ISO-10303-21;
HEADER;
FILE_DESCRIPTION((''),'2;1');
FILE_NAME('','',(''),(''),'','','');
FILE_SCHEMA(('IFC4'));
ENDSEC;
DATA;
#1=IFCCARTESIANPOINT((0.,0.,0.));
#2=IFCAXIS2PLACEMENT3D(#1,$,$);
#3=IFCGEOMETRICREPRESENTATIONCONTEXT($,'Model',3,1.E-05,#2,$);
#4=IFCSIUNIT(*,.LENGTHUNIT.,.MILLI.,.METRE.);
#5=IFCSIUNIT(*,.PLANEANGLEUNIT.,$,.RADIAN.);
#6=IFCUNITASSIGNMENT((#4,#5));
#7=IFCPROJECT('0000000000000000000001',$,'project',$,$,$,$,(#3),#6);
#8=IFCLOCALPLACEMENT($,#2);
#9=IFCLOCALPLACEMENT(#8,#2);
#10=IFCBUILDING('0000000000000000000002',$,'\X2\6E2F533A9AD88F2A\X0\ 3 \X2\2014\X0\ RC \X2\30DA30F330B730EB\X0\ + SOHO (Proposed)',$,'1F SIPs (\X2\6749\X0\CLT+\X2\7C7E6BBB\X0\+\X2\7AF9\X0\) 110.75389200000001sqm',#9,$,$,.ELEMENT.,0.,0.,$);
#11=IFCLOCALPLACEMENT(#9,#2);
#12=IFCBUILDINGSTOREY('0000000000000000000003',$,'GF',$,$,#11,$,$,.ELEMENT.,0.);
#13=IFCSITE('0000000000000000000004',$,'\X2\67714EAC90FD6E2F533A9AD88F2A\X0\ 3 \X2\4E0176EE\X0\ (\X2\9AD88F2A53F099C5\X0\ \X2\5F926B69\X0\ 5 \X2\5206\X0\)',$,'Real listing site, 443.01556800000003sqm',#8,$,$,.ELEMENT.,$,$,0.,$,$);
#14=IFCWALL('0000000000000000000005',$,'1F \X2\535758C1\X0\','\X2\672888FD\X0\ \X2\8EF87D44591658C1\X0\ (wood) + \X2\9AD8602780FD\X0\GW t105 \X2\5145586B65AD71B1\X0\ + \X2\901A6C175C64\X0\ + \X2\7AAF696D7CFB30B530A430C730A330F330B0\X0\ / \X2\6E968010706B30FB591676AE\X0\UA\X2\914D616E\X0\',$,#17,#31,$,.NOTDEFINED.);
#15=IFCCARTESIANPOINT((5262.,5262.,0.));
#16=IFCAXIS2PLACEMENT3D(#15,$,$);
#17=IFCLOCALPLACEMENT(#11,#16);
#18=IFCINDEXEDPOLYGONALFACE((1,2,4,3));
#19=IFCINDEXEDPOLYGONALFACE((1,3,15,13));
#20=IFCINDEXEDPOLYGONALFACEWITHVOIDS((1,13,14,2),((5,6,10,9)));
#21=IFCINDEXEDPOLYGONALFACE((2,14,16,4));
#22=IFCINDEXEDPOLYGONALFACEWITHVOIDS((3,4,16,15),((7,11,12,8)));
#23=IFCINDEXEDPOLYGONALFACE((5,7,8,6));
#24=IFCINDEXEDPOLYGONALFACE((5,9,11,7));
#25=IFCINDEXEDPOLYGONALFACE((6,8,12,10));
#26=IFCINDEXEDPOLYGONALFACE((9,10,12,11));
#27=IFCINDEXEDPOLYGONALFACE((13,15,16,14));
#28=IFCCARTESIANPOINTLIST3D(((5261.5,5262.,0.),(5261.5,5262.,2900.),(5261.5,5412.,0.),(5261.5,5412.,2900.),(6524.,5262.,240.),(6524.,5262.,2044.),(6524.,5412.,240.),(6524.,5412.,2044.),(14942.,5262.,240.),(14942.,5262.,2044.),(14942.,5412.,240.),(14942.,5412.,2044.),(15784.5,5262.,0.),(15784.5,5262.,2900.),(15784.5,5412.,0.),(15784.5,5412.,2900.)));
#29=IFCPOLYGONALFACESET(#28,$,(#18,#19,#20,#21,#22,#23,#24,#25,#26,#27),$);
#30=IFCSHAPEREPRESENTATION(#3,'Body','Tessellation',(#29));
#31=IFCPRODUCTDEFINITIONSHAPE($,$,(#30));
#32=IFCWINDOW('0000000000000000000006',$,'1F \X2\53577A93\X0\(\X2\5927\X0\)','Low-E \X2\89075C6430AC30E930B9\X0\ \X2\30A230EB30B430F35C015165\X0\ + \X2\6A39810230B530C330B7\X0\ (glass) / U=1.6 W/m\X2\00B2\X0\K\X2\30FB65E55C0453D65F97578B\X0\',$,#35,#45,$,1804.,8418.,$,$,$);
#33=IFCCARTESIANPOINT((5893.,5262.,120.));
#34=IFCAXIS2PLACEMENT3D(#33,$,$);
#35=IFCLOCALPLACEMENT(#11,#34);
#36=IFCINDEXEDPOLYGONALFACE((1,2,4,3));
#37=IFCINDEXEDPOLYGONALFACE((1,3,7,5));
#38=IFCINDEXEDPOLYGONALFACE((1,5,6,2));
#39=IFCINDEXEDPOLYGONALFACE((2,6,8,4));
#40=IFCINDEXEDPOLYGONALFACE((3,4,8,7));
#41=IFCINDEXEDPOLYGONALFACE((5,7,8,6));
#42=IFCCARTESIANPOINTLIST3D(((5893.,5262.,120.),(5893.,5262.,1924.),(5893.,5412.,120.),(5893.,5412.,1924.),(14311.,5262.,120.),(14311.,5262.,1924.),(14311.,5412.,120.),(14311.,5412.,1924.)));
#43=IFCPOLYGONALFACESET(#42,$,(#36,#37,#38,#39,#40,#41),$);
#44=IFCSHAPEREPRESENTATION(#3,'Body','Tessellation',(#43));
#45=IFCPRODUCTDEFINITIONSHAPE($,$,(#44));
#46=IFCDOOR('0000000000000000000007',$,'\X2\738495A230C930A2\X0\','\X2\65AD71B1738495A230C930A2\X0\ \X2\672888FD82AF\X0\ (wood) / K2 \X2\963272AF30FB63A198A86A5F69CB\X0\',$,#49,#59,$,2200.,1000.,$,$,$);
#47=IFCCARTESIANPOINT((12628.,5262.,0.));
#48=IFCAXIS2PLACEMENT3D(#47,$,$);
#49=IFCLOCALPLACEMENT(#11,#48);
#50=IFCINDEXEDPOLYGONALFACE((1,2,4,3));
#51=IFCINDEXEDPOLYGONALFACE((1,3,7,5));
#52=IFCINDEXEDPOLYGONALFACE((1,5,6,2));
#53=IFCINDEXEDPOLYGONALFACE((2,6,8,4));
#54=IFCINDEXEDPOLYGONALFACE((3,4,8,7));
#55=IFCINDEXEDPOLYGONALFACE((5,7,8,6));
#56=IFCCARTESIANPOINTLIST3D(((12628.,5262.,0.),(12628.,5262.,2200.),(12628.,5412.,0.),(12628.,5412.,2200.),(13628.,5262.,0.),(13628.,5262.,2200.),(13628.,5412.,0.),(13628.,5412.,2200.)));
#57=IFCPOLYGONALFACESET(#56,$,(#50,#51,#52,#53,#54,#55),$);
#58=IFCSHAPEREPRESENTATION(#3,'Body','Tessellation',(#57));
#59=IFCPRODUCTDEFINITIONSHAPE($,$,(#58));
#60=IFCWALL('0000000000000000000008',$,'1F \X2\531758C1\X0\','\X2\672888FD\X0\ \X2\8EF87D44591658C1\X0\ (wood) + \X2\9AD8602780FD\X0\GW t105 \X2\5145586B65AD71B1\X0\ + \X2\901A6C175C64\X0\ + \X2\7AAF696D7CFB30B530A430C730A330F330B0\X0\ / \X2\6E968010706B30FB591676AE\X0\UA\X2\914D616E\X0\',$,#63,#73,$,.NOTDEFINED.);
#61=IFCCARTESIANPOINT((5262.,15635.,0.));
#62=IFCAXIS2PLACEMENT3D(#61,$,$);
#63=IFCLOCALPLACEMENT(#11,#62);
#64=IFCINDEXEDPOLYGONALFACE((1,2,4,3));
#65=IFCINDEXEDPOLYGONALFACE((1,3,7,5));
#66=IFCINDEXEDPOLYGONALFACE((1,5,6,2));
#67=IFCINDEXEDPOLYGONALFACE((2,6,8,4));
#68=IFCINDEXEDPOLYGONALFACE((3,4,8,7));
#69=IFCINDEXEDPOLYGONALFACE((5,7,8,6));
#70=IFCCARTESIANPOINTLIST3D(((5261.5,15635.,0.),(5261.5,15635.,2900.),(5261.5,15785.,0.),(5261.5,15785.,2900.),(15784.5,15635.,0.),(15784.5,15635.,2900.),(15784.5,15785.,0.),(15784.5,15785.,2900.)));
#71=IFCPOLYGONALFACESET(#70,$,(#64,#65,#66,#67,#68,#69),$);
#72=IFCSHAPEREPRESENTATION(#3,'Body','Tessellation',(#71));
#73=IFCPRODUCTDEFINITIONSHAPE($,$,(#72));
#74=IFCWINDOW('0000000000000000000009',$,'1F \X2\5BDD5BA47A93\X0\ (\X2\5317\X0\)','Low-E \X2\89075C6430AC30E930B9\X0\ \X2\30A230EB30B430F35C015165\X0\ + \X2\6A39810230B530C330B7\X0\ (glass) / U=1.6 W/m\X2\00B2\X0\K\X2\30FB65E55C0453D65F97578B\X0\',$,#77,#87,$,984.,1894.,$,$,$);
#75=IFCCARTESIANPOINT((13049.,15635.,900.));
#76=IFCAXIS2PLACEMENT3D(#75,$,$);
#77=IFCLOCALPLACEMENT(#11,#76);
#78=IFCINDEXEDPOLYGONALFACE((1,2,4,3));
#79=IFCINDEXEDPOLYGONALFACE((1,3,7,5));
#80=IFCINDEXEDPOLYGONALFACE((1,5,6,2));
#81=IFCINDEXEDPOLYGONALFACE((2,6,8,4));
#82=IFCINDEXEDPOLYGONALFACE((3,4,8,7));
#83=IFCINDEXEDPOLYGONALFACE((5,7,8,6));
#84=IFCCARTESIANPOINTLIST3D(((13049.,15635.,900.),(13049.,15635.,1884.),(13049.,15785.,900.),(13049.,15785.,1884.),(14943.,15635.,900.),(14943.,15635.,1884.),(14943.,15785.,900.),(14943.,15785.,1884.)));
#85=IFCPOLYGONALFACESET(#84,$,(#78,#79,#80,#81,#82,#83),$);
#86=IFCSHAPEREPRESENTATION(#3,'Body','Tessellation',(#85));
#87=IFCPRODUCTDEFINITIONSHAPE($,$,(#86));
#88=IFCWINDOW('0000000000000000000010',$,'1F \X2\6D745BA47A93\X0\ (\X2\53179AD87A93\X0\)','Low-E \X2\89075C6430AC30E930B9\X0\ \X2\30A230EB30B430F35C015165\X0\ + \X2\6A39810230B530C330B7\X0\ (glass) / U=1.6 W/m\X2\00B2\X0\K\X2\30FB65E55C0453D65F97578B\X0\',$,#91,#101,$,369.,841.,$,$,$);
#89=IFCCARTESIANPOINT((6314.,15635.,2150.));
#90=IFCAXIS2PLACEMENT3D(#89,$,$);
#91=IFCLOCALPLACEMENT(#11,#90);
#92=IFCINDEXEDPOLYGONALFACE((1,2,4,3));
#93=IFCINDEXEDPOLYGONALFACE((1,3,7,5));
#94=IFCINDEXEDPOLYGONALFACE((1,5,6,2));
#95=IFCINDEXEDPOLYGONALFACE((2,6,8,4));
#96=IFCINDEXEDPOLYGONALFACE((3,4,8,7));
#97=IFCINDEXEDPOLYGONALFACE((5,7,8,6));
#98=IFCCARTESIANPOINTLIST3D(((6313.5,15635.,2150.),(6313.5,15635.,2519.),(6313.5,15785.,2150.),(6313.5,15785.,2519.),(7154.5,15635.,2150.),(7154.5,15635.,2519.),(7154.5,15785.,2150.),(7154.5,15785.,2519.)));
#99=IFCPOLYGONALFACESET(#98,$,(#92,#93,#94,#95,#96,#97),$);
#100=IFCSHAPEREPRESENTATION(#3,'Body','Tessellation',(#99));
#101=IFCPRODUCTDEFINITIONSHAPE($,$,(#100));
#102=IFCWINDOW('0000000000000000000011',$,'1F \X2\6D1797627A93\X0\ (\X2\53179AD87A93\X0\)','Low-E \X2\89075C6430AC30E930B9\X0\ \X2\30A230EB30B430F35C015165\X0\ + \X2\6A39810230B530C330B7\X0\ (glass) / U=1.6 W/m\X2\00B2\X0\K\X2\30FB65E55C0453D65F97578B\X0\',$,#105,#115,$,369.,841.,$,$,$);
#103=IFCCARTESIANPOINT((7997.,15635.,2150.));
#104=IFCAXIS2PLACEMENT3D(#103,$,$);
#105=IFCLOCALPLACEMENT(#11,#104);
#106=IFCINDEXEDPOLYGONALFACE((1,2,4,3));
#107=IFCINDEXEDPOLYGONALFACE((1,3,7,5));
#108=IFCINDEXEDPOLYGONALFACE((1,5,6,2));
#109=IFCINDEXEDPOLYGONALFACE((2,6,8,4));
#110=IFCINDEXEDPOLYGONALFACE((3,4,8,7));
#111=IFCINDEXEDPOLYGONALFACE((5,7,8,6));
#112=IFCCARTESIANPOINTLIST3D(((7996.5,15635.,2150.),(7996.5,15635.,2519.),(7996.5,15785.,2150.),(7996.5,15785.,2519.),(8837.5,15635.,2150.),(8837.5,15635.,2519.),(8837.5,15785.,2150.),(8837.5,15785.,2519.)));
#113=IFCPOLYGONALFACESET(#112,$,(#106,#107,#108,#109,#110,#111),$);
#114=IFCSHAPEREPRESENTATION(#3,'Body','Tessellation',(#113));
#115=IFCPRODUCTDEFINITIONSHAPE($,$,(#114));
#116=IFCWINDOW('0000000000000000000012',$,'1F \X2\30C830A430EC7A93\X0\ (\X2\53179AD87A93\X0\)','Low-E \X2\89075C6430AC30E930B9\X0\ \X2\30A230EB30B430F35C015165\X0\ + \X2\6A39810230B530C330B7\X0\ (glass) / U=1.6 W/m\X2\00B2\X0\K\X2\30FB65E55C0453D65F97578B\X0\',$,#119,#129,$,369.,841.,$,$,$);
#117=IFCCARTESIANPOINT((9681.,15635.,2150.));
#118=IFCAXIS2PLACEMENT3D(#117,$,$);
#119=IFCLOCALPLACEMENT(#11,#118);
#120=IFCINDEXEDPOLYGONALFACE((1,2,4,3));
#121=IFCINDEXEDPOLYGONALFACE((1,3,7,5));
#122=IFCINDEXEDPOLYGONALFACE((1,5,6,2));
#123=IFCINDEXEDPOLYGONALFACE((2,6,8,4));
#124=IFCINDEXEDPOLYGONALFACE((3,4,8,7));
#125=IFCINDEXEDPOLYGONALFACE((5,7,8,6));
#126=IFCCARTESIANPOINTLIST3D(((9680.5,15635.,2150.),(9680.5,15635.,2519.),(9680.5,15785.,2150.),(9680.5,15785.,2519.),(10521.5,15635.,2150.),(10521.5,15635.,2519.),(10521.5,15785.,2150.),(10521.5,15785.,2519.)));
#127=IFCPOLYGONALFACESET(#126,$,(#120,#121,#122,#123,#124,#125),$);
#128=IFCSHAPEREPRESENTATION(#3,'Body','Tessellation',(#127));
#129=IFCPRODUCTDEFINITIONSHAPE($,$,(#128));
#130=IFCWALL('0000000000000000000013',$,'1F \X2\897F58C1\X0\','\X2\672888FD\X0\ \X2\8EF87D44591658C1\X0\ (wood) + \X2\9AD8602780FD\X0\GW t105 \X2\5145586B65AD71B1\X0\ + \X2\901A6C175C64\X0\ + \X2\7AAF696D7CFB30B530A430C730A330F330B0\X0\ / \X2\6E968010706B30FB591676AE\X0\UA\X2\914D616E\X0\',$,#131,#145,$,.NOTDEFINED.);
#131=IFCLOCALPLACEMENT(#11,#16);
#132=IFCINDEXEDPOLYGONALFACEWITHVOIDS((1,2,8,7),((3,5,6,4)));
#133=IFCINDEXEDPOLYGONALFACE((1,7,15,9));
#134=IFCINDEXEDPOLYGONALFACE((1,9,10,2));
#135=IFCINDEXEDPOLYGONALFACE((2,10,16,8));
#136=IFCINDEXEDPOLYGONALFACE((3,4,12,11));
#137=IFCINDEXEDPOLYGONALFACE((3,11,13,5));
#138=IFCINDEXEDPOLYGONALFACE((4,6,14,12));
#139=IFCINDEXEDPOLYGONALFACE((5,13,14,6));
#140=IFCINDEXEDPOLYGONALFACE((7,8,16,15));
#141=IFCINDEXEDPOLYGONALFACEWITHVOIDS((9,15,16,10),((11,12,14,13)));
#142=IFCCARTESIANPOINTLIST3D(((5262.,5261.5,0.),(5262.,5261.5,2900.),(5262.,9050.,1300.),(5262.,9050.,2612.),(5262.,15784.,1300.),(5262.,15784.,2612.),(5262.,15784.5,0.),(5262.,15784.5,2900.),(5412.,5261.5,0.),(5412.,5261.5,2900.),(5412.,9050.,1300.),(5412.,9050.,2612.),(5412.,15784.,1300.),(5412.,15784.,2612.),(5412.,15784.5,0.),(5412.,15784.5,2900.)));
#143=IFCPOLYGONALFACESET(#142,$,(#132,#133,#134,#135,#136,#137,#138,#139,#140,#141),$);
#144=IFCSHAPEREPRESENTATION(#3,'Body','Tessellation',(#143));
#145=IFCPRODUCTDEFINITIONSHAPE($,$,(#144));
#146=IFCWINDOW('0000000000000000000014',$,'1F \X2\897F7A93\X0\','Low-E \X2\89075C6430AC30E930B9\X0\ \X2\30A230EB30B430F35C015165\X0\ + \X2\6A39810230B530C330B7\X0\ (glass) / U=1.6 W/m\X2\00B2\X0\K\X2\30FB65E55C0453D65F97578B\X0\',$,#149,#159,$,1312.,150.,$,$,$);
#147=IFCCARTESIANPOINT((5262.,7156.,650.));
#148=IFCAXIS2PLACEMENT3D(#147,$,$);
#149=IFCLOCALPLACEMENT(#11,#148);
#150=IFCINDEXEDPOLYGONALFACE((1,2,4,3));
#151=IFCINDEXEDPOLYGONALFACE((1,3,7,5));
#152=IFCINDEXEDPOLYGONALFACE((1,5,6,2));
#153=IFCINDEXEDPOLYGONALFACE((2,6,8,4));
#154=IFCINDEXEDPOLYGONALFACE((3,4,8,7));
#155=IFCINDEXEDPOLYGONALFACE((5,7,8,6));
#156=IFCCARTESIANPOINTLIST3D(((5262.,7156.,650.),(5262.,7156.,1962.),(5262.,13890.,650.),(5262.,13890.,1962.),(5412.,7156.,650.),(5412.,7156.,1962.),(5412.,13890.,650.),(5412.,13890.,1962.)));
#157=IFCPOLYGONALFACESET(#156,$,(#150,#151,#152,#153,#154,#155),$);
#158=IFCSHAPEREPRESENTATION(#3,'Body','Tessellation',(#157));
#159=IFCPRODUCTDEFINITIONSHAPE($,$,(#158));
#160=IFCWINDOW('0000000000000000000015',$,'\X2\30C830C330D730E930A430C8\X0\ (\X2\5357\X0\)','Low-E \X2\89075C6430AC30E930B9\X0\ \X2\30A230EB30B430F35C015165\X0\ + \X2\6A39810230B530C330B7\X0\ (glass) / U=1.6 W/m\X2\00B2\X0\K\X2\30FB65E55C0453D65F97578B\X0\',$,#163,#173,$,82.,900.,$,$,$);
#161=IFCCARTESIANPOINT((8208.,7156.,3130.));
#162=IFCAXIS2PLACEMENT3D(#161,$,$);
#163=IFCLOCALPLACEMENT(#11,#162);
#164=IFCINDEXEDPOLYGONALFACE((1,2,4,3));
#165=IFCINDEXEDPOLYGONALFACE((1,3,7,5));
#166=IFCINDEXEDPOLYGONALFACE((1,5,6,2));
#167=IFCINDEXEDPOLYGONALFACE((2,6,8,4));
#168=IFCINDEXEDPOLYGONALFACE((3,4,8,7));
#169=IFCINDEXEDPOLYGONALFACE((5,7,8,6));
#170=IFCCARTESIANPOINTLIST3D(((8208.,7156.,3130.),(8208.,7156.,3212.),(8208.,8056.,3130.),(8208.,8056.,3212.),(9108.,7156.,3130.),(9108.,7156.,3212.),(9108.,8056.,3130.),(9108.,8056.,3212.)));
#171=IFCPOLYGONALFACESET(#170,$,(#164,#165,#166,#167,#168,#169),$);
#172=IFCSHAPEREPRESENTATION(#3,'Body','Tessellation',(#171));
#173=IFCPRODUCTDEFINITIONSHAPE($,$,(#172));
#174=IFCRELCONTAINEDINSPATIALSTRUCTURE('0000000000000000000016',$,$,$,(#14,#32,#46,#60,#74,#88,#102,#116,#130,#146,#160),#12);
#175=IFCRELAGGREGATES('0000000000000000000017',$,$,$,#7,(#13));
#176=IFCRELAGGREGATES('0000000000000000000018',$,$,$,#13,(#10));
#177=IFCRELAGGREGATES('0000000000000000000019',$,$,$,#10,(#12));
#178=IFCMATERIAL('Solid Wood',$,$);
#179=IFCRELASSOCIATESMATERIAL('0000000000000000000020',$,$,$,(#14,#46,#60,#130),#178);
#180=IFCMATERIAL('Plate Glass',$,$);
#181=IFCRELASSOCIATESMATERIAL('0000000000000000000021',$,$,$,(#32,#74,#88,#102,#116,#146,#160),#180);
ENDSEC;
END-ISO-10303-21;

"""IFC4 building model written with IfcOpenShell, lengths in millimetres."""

from ifc_helpers import new_model, si_unit, frame, frame_2d, origin, place, context, project, spatial, rectangle, extrude, material, element, fill, save


model = new_model("IFC4")

# Units and contexts
model_context = context("Model", 3, precision=1e-05, world=origin())
ifc_project = project(units=[si_unit("LENGTHUNIT", "METRE", prefix="MILLI"), si_unit("PLANEANGLEUNIT", "RADIAN")], contexts=[model_context])

# Site, building, storey
site_placement = place(None, origin())
site = spatial("IfcSite", under=ifc_project, at=site_placement, Name="東京都港区高輪 3 丁目 (高輪台駅 徒歩 5 分)", ObjectType="Real listing site, 443.01556800000003sqm", CompositionType="ELEMENT", RefElevation=0.0)
building_placement = place(site_placement, origin())
building = spatial("IfcBuilding", under=site, at=building_placement, Name="港区高輪 3 — RC ペンシル + SOHO (Proposed)", ObjectType="1F SIPs (杉CLT+籾殻+竹) 110.75389200000001sqm", CompositionType="ELEMENT", ElevationOfRefHeight=0.0, ElevationOfTerrain=0.0)
storey_placement = place(building_placement, origin())
storey = spatial("IfcBuildingStorey", under=building, at=storey_placement, Name="GF", CompositionType="ELEMENT", Elevation=0.0)

# Shared definitions
ifc_material_1 = material(Name="Solid Wood")

# Wall, openings, window, door
wall_1_placement = place(storey_placement, frame((5262.0, 5262.0, 0.0)))
wall_1 = element("IfcWall", 1, at=wall_1_placement, inside=storey, material=ifc_material_1, Name="1F 南壁", Description="木製 軸組外壁 (wood) + 高性能GW t105 充填断熱 + 通気層 + 窯業系サイディング / 準耐火・外皮UA配慮", PredefinedType="NOTDEFINED", context=model_context, shape_type="SweptSolid", body=[
    extrude(rectangle(XDim=10523.0, YDim=150.0, at=frame_2d((5261.0, 75.0))), frame((5262.0, 5262.0, 0.0)), (0.0, 0.0, 1.0), 2900.0),
])
opening_1_placement = place(storey_placement, frame((5893.0, 5262.0, 120.0)))
opening_1 = element("IfcOpeningElement", 2, at=opening_1_placement, cuts=wall_1, PredefinedType="NOTDEFINED", context=model_context, shape_type="SweptSolid", body=[
    extrude(rectangle(XDim=8418.0, YDim=150.0, at=frame_2d((4209.0, 75.0))), frame((5893.0, 5262.0, 120.0)), (0.0, 0.0, 1.0), 1804.0),
])
opening_2_placement = place(storey_placement, frame((12628.0, 5262.0, 0.0)))
opening_2 = element("IfcOpeningElement", 3, at=opening_2_placement, cuts=wall_1, PredefinedType="NOTDEFINED", context=model_context, shape_type="SweptSolid", body=[
    extrude(rectangle(XDim=1000.0, YDim=150.0, at=frame_2d((500.0, 75.0))), frame((12628.0, 5262.0, 0.0)), (0.0, 0.0, 1.0), 2200.0),
])
ifc_material_2 = material(Name="Plate Glass")
window_1_placement = place(storey_placement, frame((5893.0, 5262.0, 120.0)))
window_1 = element("IfcWindow", 4, at=window_1_placement, inside=storey, material=ifc_material_2, Name="1F 南窓(大)", Description="Low-E 複層ガラス アルゴン封入 + 樹脂サッシ (glass) / U=1.6 W/m²K・日射取得型", OverallHeight=1804.0, OverallWidth=8418.0, context=model_context, shape_type="SweptSolid", body=[
    extrude(rectangle(XDim=8418.0, YDim=150.0, at=frame_2d((4209.0, 75.0))), frame((5893.0, 5262.0, 120.0)), (0.0, 0.0, 1.0), 1804.0),
])
fill(opening_1, window_1)
door_1_placement = place(storey_placement, frame((12628.0, 5262.0, 0.0)))
door_1 = element("IfcDoor", 5, at=door_1_placement, inside=storey, material=ifc_material_1, Name="玄関ドア", Description="断熱玄関ドア 木製芯 (wood) / K2 防犯・採風機構", OverallHeight=2200.0, OverallWidth=1000.0, context=model_context, shape_type="SweptSolid", body=[
    extrude(rectangle(XDim=1000.0, YDim=150.0, at=frame_2d((500.0, 75.0))), frame((12628.0, 5262.0, 0.0)), (0.0, 0.0, 1.0), 2200.0),
])
fill(opening_2, door_1)

# Wall, openings, windows
wall_2_placement = place(storey_placement, frame((5262.0, 15635.0, 0.0)))
wall_2 = element("IfcWall", 6, at=wall_2_placement, inside=storey, material=ifc_material_1, Name="1F 北壁", Description="木製 軸組外壁 (wood) + 高性能GW t105 充填断熱 + 通気層 + 窯業系サイディング / 準耐火・外皮UA配慮", PredefinedType="NOTDEFINED", context=model_context, shape_type="SweptSolid", body=[
    extrude(rectangle(XDim=10523.0, YDim=150.0, at=frame_2d((5261.0, 75.0))), frame((5262.0, 15635.0, 0.0)), (0.0, 0.0, 1.0), 2900.0),
])
opening_3_placement = place(storey_placement, frame((13049.0, 15635.0, 900.0)))
opening_3 = element("IfcOpeningElement", 7, at=opening_3_placement, cuts=wall_2, PredefinedType="NOTDEFINED", context=model_context, shape_type="SweptSolid", body=[
    extrude(rectangle(XDim=1894.0, YDim=150.0, at=frame_2d((947.0, 75.0))), frame((13049.0, 15635.0, 900.0)), (0.0, 0.0, 1.0), 984.0),
])
opening_4_placement = place(storey_placement, frame((6314.0, 15635.0, 2150.0)))
opening_4 = element("IfcOpeningElement", 8, at=opening_4_placement, cuts=wall_2, PredefinedType="NOTDEFINED", context=model_context, shape_type="SweptSolid", body=[
    extrude(rectangle(XDim=841.0, YDim=150.0, at=frame_2d((420.0, 75.0))), frame((6314.0, 15635.0, 2150.0)), (0.0, 0.0, 1.0), 369.0),
])
opening_5_placement = place(storey_placement, frame((7997.0, 15635.0, 2150.0)))
opening_5 = element("IfcOpeningElement", 9, at=opening_5_placement, cuts=wall_2, PredefinedType="NOTDEFINED", context=model_context, shape_type="SweptSolid", body=[
    extrude(rectangle(XDim=841.0, YDim=150.0, at=frame_2d((420.0, 75.0))), frame((7997.0, 15635.0, 2150.0)), (0.0, 0.0, 1.0), 369.0),
])
opening_6_placement = place(storey_placement, frame((9681.0, 15635.0, 2150.0)))
opening_6 = element("IfcOpeningElement", 10, at=opening_6_placement, cuts=wall_2, PredefinedType="NOTDEFINED", context=model_context, shape_type="SweptSolid", body=[
    extrude(rectangle(XDim=841.0, YDim=150.0, at=frame_2d((420.0, 75.0))), frame((9681.0, 15635.0, 2150.0)), (0.0, 0.0, 1.0), 369.0),
])
window_2_placement = place(storey_placement, frame((13049.0, 15635.0, 900.0)))
window_2 = element("IfcWindow", 11, at=window_2_placement, inside=storey, material=ifc_material_2, Name="1F 寝室窓 (北)", Description="Low-E 複層ガラス アルゴン封入 + 樹脂サッシ (glass) / U=1.6 W/m²K・日射取得型", OverallHeight=984.0, OverallWidth=1894.0, context=model_context, shape_type="SweptSolid", body=[
    extrude(rectangle(XDim=1894.0, YDim=150.0, at=frame_2d((947.0, 75.0))), frame((13049.0, 15635.0, 900.0)), (0.0, 0.0, 1.0), 984.0),
])
fill(opening_3, window_2)
window_3_placement = place(storey_placement, frame((6314.0, 15635.0, 2150.0)))
window_3 = element("IfcWindow", 12, at=window_3_placement, inside=storey, material=ifc_material_2, Name="1F 浴室窓 (北高窓)", Description="Low-E 複層ガラス アルゴン封入 + 樹脂サッシ (glass) / U=1.6 W/m²K・日射取得型", OverallHeight=369.0, OverallWidth=841.0, context=model_context, shape_type="SweptSolid", body=[
    extrude(rectangle(XDim=841.0, YDim=150.0, at=frame_2d((420.0, 75.0))), frame((6314.0, 15635.0, 2150.0)), (0.0, 0.0, 1.0), 369.0),
])
fill(opening_4, window_3)
window_4_placement = place(storey_placement, frame((7997.0, 15635.0, 2150.0)))
window_4 = element("IfcWindow", 13, at=window_4_placement, inside=storey, material=ifc_material_2, Name="1F 洗面窓 (北高窓)", Description="Low-E 複層ガラス アルゴン封入 + 樹脂サッシ (glass) / U=1.6 W/m²K・日射取得型", OverallHeight=369.0, OverallWidth=841.0, context=model_context, shape_type="SweptSolid", body=[
    extrude(rectangle(XDim=841.0, YDim=150.0, at=frame_2d((420.0, 75.0))), frame((7997.0, 15635.0, 2150.0)), (0.0, 0.0, 1.0), 369.0),
])
fill(opening_5, window_4)
window_5_placement = place(storey_placement, frame((9681.0, 15635.0, 2150.0)))
window_5 = element("IfcWindow", 14, at=window_5_placement, inside=storey, material=ifc_material_2, Name="1F トイレ窓 (北高窓)", Description="Low-E 複層ガラス アルゴン封入 + 樹脂サッシ (glass) / U=1.6 W/m²K・日射取得型", OverallHeight=369.0, OverallWidth=841.0, context=model_context, shape_type="SweptSolid", body=[
    extrude(rectangle(XDim=841.0, YDim=150.0, at=frame_2d((420.0, 75.0))), frame((9681.0, 15635.0, 2150.0)), (0.0, 0.0, 1.0), 369.0),
])
fill(opening_6, window_5)

# Wall, opening, window
wall_3_placement = place(storey_placement, frame((5262.0, 5262.0, 0.0)))
wall_3 = element("IfcWall", 15, at=wall_3_placement, inside=storey, material=ifc_material_1, Name="1F 西壁", Description="木製 軸組外壁 (wood) + 高性能GW t105 充填断熱 + 通気層 + 窯業系サイディング / 準耐火・外皮UA配慮", PredefinedType="NOTDEFINED", context=model_context, shape_type="SweptSolid", body=[
    extrude(rectangle(XDim=150.0, YDim=10523.0, at=frame_2d((75.0, 5261.0))), frame((5262.0, 5262.0, 0.0)), (0.0, 0.0, 1.0), 2900.0),
])
opening_7_placement = place(storey_placement, frame((5262.0, 7156.0, 650.0)))
opening_7 = element("IfcOpeningElement", 16, at=opening_7_placement, cuts=wall_3, PredefinedType="NOTDEFINED", context=model_context, shape_type="SweptSolid", body=[
    extrude(rectangle(XDim=150.0, YDim=6734.0, at=frame_2d((75.0, 3367.0))), frame((5262.0, 7156.0, 650.0)), (0.0, 0.0, 1.0), 1312.0),
])
window_6_placement = place(storey_placement, frame((5262.0, 7156.0, 650.0)))
window_6 = element("IfcWindow", 17, at=window_6_placement, inside=storey, material=ifc_material_2, Name="1F 西窓", Description="Low-E 複層ガラス アルゴン封入 + 樹脂サッシ (glass) / U=1.6 W/m²K・日射取得型", OverallHeight=1312.0, OverallWidth=150.0, context=model_context, shape_type="SweptSolid", body=[
    extrude(rectangle(XDim=150.0, YDim=6734.0, at=frame_2d((75.0, 3367.0))), frame((5262.0, 7156.0, 650.0)), (0.0, 0.0, 1.0), 1312.0),
])
fill(opening_7, window_6)

# Window
window_7_placement = place(storey_placement, frame((8208.0, 7156.0, 3130.0)))
element("IfcWindow", 18, at=window_7_placement, inside=storey, material=ifc_material_2, Name="トップライト (南)", Description="Low-E 複層ガラス アルゴン封入 + 樹脂サッシ (glass) / U=1.6 W/m²K・日射取得型", OverallHeight=82.0, OverallWidth=900.0, context=model_context, shape_type="SweptSolid", body=[
    extrude(rectangle(XDim=900.0, YDim=900.0, at=frame_2d((450.0, 450.0))), frame((8208.0, 7156.0, 3130.0)), (0.0, 0.0, 1.0), 82.0),
])

save(model, "model.ifc")
